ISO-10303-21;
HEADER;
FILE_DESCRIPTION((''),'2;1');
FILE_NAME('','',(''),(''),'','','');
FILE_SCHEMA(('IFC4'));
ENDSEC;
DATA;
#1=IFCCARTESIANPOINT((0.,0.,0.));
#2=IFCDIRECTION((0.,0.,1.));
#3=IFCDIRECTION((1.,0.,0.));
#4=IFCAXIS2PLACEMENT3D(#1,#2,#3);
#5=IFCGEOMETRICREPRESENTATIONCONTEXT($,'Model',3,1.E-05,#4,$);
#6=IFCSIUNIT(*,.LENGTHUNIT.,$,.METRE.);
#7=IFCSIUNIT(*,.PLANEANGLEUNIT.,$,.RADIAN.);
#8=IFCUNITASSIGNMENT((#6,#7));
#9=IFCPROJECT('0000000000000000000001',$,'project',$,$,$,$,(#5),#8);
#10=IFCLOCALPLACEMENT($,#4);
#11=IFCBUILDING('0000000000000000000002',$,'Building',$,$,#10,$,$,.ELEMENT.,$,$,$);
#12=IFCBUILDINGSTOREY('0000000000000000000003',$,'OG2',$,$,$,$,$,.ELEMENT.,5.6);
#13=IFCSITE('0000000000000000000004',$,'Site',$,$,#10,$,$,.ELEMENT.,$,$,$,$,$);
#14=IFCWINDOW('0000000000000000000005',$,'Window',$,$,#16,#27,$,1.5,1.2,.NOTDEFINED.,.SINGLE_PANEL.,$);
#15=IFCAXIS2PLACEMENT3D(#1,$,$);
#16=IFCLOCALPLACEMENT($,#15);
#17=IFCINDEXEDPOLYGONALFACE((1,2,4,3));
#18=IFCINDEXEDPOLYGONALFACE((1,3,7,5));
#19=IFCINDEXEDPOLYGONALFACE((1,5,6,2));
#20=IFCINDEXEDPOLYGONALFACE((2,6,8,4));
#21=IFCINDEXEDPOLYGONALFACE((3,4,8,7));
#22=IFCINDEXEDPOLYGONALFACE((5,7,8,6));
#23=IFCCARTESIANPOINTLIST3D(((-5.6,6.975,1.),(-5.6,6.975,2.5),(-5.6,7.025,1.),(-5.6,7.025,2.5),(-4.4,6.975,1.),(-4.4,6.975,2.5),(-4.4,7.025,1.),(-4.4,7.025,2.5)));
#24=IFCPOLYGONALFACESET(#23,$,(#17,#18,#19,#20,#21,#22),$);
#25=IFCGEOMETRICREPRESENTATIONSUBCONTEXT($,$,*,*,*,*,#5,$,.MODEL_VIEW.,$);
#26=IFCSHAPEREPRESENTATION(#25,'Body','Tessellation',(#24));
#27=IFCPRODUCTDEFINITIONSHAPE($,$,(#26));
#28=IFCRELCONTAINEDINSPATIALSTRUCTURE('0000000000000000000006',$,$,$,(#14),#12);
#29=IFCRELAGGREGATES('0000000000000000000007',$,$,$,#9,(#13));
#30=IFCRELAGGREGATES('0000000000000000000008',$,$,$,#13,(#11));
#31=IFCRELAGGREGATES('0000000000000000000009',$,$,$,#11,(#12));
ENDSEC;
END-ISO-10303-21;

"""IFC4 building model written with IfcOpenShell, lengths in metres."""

from ifc_helpers import new_model, si_unit, frame, origin, origin_with_axes, origin_2d, place, context, subcontext, project, spatial, rectangle, extrude, element, save


model = new_model("IFC4")

# Units and contexts
model_context = context("Model", 3, precision=1e-05, world=origin_with_axes())
sub_context = subcontext(model_context, None, None, "MODEL_VIEW")
ifc_project = project(units=[si_unit("LENGTHUNIT", "METRE"), si_unit("PLANEANGLEUNIT", "RADIAN")], contexts=[model_context])

# Site, building, storey
placement_1 = place(None, origin_with_axes())
site = spatial("IfcSite", under=ifc_project, at=placement_1, Name="Site", CompositionType="ELEMENT")
building = spatial("IfcBuilding", under=site, at=placement_1, Name="Building", CompositionType="ELEMENT")
storey = spatial("IfcBuildingStorey", under=building, Name="OG2", CompositionType="ELEMENT", Elevation=5.6)

# Window
placement_2 = place(None, origin_with_axes())
window_placement = place(placement_2, frame((-5.0, 7.0, 1.0)))
element("IfcWindow", 1, at=window_placement, inside=storey, Name="Window", OverallHeight=1.5, OverallWidth=1.2, PartitioningType="SINGLE_PANEL", PredefinedType="NOTDEFINED", context=sub_context, shape_type="SweptSolid", body=[
    extrude(rectangle(XDim=1.2, YDim=0.05, at=origin_2d()), origin(), (0.0, 0.0, 1.0), 1.5),
])

save(model, "model.ifc")
